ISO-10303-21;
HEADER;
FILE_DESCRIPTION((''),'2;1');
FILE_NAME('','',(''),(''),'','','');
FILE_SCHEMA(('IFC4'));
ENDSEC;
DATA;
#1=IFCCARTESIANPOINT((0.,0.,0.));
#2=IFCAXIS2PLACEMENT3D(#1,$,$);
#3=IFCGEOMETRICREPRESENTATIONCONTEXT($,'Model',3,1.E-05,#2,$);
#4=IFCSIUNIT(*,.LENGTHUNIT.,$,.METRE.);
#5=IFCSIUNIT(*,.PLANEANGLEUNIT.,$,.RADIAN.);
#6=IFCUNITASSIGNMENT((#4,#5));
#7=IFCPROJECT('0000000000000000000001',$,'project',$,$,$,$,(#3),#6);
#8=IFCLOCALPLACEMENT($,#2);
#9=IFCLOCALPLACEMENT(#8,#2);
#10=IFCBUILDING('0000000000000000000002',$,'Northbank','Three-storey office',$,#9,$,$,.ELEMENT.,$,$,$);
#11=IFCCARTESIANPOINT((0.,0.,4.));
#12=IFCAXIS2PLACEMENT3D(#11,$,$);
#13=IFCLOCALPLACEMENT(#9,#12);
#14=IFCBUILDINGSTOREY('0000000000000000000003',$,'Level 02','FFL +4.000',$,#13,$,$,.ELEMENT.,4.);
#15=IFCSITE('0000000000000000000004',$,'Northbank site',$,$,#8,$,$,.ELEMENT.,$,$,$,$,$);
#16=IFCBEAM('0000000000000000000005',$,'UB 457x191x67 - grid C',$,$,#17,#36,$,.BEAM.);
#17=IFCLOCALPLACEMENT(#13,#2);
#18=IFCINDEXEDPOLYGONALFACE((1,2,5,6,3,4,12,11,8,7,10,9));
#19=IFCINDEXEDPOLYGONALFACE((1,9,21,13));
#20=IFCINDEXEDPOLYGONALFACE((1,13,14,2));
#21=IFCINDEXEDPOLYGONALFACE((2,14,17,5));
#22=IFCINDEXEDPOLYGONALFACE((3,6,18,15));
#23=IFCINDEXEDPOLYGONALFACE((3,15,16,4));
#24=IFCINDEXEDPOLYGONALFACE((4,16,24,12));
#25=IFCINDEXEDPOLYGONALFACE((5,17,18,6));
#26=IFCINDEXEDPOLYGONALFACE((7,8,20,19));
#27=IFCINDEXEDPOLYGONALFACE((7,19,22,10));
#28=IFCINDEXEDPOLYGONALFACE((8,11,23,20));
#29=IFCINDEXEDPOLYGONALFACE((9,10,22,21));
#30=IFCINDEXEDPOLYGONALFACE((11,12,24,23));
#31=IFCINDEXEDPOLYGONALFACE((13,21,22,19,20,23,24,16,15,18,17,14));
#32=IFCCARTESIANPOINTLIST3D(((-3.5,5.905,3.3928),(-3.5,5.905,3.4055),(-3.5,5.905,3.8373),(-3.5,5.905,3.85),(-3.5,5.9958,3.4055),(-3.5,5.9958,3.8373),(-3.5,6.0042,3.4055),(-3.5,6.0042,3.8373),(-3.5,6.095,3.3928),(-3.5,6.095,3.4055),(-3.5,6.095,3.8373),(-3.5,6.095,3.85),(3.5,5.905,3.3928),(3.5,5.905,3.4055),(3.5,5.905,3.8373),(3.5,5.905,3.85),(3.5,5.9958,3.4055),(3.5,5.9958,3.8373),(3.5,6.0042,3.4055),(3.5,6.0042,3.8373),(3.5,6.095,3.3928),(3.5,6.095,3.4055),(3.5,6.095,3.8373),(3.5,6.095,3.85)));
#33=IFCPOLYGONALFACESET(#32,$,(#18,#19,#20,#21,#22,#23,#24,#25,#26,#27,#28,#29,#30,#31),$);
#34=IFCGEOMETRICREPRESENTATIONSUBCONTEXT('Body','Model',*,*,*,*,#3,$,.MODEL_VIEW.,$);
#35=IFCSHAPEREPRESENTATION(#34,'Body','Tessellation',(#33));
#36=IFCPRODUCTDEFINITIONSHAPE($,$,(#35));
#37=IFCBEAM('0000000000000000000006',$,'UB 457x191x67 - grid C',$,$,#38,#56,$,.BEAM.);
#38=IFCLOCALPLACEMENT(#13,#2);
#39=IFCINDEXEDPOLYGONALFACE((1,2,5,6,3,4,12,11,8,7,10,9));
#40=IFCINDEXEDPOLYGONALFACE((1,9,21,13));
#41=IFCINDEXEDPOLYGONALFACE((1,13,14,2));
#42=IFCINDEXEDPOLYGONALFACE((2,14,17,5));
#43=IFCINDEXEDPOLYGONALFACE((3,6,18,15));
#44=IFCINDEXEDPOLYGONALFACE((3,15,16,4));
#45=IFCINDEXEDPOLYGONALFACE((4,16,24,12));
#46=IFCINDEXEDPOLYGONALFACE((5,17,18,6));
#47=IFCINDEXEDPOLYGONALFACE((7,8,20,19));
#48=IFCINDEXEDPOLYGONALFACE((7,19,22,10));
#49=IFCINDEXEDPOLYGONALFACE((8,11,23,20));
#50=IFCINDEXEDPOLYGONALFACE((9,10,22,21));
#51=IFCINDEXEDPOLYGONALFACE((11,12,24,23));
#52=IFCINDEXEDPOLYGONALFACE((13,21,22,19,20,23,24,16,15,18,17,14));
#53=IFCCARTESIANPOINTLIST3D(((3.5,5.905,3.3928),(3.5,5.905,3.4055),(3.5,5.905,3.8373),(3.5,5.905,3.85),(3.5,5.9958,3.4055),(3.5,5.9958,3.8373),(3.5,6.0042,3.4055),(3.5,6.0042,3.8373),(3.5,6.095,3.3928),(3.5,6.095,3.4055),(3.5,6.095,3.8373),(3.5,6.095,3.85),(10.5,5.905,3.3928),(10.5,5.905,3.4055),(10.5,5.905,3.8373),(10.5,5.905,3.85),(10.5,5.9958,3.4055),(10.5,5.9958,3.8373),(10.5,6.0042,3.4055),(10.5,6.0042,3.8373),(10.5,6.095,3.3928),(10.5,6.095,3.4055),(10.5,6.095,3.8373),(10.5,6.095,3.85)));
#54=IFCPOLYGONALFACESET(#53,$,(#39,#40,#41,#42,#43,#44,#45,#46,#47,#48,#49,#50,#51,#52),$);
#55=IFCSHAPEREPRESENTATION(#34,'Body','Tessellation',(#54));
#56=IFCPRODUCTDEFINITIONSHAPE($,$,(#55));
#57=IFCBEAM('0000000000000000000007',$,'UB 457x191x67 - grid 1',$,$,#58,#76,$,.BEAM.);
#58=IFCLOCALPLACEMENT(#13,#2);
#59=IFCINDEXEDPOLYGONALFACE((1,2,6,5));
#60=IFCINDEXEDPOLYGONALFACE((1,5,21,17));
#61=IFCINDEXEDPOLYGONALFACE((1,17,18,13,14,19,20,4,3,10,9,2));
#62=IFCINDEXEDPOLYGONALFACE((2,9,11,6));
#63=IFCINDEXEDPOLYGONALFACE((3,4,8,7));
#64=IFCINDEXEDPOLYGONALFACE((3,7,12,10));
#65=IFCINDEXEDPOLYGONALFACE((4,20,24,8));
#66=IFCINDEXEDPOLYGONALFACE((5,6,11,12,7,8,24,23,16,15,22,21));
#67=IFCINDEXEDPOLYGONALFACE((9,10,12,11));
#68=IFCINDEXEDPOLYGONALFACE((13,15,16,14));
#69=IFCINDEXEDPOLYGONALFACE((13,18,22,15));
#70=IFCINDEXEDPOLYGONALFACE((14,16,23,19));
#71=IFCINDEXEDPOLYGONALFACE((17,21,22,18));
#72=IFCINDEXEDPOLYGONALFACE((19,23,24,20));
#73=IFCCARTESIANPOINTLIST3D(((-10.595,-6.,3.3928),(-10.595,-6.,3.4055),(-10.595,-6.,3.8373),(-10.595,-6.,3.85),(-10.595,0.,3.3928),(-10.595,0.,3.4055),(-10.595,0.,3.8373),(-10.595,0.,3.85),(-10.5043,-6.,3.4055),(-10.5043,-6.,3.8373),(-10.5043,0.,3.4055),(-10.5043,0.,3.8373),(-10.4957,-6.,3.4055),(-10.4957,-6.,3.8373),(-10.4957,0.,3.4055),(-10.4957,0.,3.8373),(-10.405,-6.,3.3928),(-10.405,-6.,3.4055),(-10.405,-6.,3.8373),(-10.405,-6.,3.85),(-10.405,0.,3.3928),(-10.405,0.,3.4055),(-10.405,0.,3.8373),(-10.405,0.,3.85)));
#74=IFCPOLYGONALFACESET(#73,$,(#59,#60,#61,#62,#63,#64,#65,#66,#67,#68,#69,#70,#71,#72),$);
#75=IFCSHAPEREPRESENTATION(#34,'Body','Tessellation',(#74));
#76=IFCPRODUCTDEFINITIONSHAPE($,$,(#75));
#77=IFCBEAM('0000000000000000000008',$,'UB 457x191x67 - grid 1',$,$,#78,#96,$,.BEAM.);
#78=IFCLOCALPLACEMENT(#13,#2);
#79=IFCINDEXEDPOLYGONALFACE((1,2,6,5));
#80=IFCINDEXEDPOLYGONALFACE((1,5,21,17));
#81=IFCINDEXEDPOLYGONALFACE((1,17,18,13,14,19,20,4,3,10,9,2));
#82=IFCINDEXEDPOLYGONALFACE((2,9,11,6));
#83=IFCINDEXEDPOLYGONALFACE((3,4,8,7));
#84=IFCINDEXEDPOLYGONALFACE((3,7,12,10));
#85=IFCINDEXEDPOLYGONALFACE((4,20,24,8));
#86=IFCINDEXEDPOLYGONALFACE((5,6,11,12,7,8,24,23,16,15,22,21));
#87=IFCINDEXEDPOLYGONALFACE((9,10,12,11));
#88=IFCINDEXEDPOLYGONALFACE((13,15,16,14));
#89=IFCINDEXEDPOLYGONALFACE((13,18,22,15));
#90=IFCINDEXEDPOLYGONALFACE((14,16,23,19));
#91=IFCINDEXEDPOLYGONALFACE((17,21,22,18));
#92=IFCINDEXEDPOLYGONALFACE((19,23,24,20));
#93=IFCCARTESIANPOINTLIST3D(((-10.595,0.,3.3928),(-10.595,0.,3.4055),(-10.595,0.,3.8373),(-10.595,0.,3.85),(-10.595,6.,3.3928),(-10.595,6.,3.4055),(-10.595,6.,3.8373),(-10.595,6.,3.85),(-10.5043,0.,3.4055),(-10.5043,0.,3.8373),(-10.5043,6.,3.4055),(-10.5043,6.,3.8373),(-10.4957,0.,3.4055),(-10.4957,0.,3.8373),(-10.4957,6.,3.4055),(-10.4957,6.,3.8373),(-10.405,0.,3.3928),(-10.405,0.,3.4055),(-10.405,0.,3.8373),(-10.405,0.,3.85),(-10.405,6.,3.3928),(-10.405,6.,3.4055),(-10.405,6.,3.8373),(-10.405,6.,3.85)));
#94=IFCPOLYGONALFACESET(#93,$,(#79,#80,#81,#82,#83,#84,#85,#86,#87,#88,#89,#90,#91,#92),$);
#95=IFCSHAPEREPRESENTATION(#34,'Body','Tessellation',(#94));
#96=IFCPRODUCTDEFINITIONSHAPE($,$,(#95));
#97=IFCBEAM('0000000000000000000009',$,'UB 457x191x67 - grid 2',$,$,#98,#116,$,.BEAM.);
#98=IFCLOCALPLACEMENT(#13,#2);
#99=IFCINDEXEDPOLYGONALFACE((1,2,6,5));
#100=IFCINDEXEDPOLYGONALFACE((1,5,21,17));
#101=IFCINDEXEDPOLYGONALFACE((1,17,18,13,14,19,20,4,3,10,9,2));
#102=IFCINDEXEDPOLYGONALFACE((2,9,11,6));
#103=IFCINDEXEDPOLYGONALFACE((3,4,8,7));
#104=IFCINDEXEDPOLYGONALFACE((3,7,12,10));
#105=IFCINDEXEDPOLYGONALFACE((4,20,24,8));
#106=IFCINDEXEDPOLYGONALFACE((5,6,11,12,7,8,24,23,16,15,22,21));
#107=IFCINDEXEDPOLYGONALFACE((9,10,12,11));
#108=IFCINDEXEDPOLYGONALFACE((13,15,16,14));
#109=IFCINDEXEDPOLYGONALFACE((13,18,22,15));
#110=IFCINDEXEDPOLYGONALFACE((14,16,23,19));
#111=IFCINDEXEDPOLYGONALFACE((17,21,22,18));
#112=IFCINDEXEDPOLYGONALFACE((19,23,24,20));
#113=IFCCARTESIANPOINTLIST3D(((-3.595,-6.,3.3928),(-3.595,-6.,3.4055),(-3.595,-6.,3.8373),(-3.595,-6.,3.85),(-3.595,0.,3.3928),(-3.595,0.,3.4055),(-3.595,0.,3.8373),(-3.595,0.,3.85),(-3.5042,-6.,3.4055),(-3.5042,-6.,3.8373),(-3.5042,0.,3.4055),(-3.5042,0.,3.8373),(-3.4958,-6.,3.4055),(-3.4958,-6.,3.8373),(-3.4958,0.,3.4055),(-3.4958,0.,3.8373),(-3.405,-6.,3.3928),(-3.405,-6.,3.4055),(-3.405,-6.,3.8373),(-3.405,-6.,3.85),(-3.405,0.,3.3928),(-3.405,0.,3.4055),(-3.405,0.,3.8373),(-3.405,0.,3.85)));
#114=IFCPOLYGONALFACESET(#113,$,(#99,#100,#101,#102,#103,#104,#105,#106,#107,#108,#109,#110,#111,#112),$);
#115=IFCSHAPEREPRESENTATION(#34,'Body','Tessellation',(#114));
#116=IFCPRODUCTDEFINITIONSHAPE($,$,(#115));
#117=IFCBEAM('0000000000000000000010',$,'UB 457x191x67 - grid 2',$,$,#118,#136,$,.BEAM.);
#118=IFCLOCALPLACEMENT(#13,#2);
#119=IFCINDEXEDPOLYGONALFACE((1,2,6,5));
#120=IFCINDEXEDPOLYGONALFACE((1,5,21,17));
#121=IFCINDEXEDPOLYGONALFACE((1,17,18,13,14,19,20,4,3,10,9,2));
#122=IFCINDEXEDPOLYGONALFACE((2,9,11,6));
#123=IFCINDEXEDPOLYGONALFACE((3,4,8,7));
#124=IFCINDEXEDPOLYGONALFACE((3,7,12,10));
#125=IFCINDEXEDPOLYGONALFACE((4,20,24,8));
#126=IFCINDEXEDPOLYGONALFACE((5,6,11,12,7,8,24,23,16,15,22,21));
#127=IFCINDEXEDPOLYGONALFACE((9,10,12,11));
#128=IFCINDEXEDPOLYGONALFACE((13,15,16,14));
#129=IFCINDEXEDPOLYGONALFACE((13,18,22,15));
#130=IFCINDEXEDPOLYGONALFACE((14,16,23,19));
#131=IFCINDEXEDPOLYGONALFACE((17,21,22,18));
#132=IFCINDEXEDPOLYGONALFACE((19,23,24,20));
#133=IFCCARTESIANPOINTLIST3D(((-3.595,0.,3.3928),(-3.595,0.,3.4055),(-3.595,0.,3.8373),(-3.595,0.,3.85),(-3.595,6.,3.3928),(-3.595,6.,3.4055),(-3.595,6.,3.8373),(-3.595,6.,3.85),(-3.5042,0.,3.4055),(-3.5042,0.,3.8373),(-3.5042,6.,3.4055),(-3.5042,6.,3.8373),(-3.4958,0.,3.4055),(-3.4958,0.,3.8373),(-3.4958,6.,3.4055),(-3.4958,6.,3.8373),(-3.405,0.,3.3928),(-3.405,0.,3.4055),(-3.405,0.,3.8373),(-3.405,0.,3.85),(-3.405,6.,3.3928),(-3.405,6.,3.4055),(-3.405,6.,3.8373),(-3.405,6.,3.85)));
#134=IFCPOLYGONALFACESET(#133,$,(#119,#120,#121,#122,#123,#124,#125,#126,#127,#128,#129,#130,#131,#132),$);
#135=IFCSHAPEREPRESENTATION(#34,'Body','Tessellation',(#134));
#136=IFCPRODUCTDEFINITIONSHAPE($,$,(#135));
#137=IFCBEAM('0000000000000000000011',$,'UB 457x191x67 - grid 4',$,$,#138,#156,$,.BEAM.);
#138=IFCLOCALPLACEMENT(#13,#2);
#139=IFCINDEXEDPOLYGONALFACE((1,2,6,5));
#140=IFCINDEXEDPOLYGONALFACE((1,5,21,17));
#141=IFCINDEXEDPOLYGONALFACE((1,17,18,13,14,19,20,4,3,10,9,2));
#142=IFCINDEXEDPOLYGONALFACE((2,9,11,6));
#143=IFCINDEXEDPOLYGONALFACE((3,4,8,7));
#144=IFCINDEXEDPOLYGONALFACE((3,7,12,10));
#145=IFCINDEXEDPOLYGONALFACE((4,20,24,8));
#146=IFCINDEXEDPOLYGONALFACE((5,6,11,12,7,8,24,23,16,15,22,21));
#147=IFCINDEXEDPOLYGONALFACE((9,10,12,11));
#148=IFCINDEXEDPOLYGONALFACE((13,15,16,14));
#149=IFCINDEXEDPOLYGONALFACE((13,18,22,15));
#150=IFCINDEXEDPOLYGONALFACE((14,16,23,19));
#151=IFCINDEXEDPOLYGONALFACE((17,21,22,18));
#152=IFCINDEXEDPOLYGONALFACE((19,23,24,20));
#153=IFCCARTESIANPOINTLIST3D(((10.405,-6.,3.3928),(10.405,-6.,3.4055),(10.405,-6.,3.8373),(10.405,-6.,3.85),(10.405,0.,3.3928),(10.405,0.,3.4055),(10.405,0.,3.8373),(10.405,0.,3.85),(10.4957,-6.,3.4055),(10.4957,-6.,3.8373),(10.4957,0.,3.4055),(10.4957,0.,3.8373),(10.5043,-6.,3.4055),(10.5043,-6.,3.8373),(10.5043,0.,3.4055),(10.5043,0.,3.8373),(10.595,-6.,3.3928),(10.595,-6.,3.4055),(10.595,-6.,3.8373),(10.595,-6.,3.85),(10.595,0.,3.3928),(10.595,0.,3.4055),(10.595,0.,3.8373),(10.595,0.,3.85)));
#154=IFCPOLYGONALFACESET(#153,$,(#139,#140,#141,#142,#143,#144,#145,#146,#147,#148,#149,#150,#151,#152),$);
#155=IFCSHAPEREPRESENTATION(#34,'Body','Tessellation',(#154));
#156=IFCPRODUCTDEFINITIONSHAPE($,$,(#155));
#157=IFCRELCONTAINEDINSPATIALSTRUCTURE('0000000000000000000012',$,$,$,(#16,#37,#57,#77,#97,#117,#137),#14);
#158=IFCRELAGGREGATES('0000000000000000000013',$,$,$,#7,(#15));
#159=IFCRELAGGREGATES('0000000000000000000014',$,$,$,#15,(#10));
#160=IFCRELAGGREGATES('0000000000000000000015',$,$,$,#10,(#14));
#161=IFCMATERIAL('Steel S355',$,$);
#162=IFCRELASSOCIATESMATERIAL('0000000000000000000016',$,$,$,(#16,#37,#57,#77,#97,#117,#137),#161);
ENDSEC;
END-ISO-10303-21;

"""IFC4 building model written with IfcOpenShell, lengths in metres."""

from ifc_helpers import new_model, si_unit, frame, origin, place, context, subcontext, project, spatial, i_section, extrude, material, element, save


model = new_model("IFC4")

# Units and contexts
model_context = context("Model", 3, precision=1e-05, world=origin())
body_context = subcontext(model_context, "Body", "Model", "MODEL_VIEW")
ifc_project = project(units=[si_unit("LENGTHUNIT", "METRE"), si_unit("PLANEANGLEUNIT", "RADIAN")], contexts=[model_context])

# Site, building, storey
site_placement = place(None, origin())
site = spatial("IfcSite", under=ifc_project, at=site_placement, Name="Northbank site", CompositionType="ELEMENT")
building_placement = place(site_placement, origin())
building = spatial("IfcBuilding", under=site, at=building_placement, Name="Northbank", Description="Three-storey office", CompositionType="ELEMENT")
storey_placement = place(building_placement, frame((0.0, 0.0, 4.0)))
storey = spatial("IfcBuildingStorey", under=building, at=storey_placement, Name="Level 02", Description="FFL +4.000", CompositionType="ELEMENT", Elevation=4.0)

# Shared definitions
ifc_material = material(Name="Steel S355")

# Beams
beam_1_placement = place(storey_placement, frame((0.0, 0.0, -4.0)))
element("IfcBeam", 1, at=beam_1_placement, inside=storey, material=ifc_material, Name="UB 457x191x67 - grid C", PredefinedType="BEAM", context=body_context, shape_type="SweptSolid", body=[
    extrude(i_section(OverallWidth=0.1899, OverallDepth=0.4572, WebThickness=0.0085, FlangeThickness=0.0127), frame((-3.5, 6.0, 7.6214), z_axis=(1.0, 0.0, 0.0), x_axis=(0.0, 1.0, 0.0)), (0.0, 0.0, 1.0), 7.0),
])
beam_2_placement = place(storey_placement, frame((0.0, 0.0, -4.0)))
element("IfcBeam", 2, at=beam_2_placement, inside=storey, material=ifc_material, Name="UB 457x191x67 - grid C", PredefinedType="BEAM", context=body_context, shape_type="SweptSolid", body=[
    extrude(i_section(OverallWidth=0.1899, OverallDepth=0.4572, WebThickness=0.0085, FlangeThickness=0.0127), frame((3.5, 6.0, 7.6214), z_axis=(1.0, 0.0, 0.0), x_axis=(0.0, 1.0, 0.0)), (0.0, 0.0, 1.0), 7.0),
])
beam_3_placement = place(storey_placement, frame((0.0, 0.0, -4.0)))
element("IfcBeam", 3, at=beam_3_placement, inside=storey, material=ifc_material, Name="UB 457x191x67 - grid 1", PredefinedType="BEAM", context=body_context, shape_type="SweptSolid", body=[
    extrude(i_section(OverallWidth=0.1899, OverallDepth=0.4572, WebThickness=0.0085, FlangeThickness=0.0127), frame((-10.5, -6.0, 7.6214), z_axis=(0.0, 1.0, 0.0), x_axis=(-1.0, 0.0, 0.0)), (0.0, 0.0, 1.0), 6.0),
])
beam_4_placement = place(storey_placement, frame((0.0, 0.0, -4.0)))
element("IfcBeam", 4, at=beam_4_placement, inside=storey, material=ifc_material, Name="UB 457x191x67 - grid 1", PredefinedType="BEAM", context=body_context, shape_type="SweptSolid", body=[
    extrude(i_section(OverallWidth=0.1899, OverallDepth=0.4572, WebThickness=0.0085, FlangeThickness=0.0127), frame((-10.5, 0.0, 7.6214), z_axis=(0.0, 1.0, 0.0), x_axis=(-1.0, 0.0, 0.0)), (0.0, 0.0, 1.0), 6.0),
])
beam_5_placement = place(storey_placement, frame((0.0, 0.0, -4.0)))
element("IfcBeam", 5, at=beam_5_placement, inside=storey, material=ifc_material, Name="UB 457x191x67 - grid 2", PredefinedType="BEAM", context=body_context, shape_type="SweptSolid", body=[
    extrude(i_section(OverallWidth=0.1899, OverallDepth=0.4572, WebThickness=0.0085, FlangeThickness=0.0127), frame((-3.5, -6.0, 7.6214), z_axis=(0.0, 1.0, 0.0), x_axis=(-1.0, 0.0, 0.0)), (0.0, 0.0, 1.0), 6.0),
])
beam_6_placement = place(storey_placement, frame((0.0, 0.0, -4.0)))
element("IfcBeam", 6, at=beam_6_placement, inside=storey, material=ifc_material, Name="UB 457x191x67 - grid 2", PredefinedType="BEAM", context=body_context, shape_type="SweptSolid", body=[
    extrude(i_section(OverallWidth=0.1899, OverallDepth=0.4572, WebThickness=0.0085, FlangeThickness=0.0127), frame((-3.5, 0.0, 7.6214), z_axis=(0.0, 1.0, 0.0), x_axis=(-1.0, 0.0, 0.0)), (0.0, 0.0, 1.0), 6.0),
])
beam_7_placement = place(storey_placement, frame((0.0, 0.0, -4.0)))
element("IfcBeam", 7, at=beam_7_placement, inside=storey, material=ifc_material, Name="UB 457x191x67 - grid 4", PredefinedType="BEAM", context=body_context, shape_type="SweptSolid", body=[
    extrude(i_section(OverallWidth=0.1899, OverallDepth=0.4572, WebThickness=0.0085, FlangeThickness=0.0127), frame((10.5, -6.0, 7.6214), z_axis=(0.0, 1.0, 0.0), x_axis=(-1.0, 0.0, 0.0)), (0.0, 0.0, 1.0), 6.0),
])

save(model, "model.ifc")
